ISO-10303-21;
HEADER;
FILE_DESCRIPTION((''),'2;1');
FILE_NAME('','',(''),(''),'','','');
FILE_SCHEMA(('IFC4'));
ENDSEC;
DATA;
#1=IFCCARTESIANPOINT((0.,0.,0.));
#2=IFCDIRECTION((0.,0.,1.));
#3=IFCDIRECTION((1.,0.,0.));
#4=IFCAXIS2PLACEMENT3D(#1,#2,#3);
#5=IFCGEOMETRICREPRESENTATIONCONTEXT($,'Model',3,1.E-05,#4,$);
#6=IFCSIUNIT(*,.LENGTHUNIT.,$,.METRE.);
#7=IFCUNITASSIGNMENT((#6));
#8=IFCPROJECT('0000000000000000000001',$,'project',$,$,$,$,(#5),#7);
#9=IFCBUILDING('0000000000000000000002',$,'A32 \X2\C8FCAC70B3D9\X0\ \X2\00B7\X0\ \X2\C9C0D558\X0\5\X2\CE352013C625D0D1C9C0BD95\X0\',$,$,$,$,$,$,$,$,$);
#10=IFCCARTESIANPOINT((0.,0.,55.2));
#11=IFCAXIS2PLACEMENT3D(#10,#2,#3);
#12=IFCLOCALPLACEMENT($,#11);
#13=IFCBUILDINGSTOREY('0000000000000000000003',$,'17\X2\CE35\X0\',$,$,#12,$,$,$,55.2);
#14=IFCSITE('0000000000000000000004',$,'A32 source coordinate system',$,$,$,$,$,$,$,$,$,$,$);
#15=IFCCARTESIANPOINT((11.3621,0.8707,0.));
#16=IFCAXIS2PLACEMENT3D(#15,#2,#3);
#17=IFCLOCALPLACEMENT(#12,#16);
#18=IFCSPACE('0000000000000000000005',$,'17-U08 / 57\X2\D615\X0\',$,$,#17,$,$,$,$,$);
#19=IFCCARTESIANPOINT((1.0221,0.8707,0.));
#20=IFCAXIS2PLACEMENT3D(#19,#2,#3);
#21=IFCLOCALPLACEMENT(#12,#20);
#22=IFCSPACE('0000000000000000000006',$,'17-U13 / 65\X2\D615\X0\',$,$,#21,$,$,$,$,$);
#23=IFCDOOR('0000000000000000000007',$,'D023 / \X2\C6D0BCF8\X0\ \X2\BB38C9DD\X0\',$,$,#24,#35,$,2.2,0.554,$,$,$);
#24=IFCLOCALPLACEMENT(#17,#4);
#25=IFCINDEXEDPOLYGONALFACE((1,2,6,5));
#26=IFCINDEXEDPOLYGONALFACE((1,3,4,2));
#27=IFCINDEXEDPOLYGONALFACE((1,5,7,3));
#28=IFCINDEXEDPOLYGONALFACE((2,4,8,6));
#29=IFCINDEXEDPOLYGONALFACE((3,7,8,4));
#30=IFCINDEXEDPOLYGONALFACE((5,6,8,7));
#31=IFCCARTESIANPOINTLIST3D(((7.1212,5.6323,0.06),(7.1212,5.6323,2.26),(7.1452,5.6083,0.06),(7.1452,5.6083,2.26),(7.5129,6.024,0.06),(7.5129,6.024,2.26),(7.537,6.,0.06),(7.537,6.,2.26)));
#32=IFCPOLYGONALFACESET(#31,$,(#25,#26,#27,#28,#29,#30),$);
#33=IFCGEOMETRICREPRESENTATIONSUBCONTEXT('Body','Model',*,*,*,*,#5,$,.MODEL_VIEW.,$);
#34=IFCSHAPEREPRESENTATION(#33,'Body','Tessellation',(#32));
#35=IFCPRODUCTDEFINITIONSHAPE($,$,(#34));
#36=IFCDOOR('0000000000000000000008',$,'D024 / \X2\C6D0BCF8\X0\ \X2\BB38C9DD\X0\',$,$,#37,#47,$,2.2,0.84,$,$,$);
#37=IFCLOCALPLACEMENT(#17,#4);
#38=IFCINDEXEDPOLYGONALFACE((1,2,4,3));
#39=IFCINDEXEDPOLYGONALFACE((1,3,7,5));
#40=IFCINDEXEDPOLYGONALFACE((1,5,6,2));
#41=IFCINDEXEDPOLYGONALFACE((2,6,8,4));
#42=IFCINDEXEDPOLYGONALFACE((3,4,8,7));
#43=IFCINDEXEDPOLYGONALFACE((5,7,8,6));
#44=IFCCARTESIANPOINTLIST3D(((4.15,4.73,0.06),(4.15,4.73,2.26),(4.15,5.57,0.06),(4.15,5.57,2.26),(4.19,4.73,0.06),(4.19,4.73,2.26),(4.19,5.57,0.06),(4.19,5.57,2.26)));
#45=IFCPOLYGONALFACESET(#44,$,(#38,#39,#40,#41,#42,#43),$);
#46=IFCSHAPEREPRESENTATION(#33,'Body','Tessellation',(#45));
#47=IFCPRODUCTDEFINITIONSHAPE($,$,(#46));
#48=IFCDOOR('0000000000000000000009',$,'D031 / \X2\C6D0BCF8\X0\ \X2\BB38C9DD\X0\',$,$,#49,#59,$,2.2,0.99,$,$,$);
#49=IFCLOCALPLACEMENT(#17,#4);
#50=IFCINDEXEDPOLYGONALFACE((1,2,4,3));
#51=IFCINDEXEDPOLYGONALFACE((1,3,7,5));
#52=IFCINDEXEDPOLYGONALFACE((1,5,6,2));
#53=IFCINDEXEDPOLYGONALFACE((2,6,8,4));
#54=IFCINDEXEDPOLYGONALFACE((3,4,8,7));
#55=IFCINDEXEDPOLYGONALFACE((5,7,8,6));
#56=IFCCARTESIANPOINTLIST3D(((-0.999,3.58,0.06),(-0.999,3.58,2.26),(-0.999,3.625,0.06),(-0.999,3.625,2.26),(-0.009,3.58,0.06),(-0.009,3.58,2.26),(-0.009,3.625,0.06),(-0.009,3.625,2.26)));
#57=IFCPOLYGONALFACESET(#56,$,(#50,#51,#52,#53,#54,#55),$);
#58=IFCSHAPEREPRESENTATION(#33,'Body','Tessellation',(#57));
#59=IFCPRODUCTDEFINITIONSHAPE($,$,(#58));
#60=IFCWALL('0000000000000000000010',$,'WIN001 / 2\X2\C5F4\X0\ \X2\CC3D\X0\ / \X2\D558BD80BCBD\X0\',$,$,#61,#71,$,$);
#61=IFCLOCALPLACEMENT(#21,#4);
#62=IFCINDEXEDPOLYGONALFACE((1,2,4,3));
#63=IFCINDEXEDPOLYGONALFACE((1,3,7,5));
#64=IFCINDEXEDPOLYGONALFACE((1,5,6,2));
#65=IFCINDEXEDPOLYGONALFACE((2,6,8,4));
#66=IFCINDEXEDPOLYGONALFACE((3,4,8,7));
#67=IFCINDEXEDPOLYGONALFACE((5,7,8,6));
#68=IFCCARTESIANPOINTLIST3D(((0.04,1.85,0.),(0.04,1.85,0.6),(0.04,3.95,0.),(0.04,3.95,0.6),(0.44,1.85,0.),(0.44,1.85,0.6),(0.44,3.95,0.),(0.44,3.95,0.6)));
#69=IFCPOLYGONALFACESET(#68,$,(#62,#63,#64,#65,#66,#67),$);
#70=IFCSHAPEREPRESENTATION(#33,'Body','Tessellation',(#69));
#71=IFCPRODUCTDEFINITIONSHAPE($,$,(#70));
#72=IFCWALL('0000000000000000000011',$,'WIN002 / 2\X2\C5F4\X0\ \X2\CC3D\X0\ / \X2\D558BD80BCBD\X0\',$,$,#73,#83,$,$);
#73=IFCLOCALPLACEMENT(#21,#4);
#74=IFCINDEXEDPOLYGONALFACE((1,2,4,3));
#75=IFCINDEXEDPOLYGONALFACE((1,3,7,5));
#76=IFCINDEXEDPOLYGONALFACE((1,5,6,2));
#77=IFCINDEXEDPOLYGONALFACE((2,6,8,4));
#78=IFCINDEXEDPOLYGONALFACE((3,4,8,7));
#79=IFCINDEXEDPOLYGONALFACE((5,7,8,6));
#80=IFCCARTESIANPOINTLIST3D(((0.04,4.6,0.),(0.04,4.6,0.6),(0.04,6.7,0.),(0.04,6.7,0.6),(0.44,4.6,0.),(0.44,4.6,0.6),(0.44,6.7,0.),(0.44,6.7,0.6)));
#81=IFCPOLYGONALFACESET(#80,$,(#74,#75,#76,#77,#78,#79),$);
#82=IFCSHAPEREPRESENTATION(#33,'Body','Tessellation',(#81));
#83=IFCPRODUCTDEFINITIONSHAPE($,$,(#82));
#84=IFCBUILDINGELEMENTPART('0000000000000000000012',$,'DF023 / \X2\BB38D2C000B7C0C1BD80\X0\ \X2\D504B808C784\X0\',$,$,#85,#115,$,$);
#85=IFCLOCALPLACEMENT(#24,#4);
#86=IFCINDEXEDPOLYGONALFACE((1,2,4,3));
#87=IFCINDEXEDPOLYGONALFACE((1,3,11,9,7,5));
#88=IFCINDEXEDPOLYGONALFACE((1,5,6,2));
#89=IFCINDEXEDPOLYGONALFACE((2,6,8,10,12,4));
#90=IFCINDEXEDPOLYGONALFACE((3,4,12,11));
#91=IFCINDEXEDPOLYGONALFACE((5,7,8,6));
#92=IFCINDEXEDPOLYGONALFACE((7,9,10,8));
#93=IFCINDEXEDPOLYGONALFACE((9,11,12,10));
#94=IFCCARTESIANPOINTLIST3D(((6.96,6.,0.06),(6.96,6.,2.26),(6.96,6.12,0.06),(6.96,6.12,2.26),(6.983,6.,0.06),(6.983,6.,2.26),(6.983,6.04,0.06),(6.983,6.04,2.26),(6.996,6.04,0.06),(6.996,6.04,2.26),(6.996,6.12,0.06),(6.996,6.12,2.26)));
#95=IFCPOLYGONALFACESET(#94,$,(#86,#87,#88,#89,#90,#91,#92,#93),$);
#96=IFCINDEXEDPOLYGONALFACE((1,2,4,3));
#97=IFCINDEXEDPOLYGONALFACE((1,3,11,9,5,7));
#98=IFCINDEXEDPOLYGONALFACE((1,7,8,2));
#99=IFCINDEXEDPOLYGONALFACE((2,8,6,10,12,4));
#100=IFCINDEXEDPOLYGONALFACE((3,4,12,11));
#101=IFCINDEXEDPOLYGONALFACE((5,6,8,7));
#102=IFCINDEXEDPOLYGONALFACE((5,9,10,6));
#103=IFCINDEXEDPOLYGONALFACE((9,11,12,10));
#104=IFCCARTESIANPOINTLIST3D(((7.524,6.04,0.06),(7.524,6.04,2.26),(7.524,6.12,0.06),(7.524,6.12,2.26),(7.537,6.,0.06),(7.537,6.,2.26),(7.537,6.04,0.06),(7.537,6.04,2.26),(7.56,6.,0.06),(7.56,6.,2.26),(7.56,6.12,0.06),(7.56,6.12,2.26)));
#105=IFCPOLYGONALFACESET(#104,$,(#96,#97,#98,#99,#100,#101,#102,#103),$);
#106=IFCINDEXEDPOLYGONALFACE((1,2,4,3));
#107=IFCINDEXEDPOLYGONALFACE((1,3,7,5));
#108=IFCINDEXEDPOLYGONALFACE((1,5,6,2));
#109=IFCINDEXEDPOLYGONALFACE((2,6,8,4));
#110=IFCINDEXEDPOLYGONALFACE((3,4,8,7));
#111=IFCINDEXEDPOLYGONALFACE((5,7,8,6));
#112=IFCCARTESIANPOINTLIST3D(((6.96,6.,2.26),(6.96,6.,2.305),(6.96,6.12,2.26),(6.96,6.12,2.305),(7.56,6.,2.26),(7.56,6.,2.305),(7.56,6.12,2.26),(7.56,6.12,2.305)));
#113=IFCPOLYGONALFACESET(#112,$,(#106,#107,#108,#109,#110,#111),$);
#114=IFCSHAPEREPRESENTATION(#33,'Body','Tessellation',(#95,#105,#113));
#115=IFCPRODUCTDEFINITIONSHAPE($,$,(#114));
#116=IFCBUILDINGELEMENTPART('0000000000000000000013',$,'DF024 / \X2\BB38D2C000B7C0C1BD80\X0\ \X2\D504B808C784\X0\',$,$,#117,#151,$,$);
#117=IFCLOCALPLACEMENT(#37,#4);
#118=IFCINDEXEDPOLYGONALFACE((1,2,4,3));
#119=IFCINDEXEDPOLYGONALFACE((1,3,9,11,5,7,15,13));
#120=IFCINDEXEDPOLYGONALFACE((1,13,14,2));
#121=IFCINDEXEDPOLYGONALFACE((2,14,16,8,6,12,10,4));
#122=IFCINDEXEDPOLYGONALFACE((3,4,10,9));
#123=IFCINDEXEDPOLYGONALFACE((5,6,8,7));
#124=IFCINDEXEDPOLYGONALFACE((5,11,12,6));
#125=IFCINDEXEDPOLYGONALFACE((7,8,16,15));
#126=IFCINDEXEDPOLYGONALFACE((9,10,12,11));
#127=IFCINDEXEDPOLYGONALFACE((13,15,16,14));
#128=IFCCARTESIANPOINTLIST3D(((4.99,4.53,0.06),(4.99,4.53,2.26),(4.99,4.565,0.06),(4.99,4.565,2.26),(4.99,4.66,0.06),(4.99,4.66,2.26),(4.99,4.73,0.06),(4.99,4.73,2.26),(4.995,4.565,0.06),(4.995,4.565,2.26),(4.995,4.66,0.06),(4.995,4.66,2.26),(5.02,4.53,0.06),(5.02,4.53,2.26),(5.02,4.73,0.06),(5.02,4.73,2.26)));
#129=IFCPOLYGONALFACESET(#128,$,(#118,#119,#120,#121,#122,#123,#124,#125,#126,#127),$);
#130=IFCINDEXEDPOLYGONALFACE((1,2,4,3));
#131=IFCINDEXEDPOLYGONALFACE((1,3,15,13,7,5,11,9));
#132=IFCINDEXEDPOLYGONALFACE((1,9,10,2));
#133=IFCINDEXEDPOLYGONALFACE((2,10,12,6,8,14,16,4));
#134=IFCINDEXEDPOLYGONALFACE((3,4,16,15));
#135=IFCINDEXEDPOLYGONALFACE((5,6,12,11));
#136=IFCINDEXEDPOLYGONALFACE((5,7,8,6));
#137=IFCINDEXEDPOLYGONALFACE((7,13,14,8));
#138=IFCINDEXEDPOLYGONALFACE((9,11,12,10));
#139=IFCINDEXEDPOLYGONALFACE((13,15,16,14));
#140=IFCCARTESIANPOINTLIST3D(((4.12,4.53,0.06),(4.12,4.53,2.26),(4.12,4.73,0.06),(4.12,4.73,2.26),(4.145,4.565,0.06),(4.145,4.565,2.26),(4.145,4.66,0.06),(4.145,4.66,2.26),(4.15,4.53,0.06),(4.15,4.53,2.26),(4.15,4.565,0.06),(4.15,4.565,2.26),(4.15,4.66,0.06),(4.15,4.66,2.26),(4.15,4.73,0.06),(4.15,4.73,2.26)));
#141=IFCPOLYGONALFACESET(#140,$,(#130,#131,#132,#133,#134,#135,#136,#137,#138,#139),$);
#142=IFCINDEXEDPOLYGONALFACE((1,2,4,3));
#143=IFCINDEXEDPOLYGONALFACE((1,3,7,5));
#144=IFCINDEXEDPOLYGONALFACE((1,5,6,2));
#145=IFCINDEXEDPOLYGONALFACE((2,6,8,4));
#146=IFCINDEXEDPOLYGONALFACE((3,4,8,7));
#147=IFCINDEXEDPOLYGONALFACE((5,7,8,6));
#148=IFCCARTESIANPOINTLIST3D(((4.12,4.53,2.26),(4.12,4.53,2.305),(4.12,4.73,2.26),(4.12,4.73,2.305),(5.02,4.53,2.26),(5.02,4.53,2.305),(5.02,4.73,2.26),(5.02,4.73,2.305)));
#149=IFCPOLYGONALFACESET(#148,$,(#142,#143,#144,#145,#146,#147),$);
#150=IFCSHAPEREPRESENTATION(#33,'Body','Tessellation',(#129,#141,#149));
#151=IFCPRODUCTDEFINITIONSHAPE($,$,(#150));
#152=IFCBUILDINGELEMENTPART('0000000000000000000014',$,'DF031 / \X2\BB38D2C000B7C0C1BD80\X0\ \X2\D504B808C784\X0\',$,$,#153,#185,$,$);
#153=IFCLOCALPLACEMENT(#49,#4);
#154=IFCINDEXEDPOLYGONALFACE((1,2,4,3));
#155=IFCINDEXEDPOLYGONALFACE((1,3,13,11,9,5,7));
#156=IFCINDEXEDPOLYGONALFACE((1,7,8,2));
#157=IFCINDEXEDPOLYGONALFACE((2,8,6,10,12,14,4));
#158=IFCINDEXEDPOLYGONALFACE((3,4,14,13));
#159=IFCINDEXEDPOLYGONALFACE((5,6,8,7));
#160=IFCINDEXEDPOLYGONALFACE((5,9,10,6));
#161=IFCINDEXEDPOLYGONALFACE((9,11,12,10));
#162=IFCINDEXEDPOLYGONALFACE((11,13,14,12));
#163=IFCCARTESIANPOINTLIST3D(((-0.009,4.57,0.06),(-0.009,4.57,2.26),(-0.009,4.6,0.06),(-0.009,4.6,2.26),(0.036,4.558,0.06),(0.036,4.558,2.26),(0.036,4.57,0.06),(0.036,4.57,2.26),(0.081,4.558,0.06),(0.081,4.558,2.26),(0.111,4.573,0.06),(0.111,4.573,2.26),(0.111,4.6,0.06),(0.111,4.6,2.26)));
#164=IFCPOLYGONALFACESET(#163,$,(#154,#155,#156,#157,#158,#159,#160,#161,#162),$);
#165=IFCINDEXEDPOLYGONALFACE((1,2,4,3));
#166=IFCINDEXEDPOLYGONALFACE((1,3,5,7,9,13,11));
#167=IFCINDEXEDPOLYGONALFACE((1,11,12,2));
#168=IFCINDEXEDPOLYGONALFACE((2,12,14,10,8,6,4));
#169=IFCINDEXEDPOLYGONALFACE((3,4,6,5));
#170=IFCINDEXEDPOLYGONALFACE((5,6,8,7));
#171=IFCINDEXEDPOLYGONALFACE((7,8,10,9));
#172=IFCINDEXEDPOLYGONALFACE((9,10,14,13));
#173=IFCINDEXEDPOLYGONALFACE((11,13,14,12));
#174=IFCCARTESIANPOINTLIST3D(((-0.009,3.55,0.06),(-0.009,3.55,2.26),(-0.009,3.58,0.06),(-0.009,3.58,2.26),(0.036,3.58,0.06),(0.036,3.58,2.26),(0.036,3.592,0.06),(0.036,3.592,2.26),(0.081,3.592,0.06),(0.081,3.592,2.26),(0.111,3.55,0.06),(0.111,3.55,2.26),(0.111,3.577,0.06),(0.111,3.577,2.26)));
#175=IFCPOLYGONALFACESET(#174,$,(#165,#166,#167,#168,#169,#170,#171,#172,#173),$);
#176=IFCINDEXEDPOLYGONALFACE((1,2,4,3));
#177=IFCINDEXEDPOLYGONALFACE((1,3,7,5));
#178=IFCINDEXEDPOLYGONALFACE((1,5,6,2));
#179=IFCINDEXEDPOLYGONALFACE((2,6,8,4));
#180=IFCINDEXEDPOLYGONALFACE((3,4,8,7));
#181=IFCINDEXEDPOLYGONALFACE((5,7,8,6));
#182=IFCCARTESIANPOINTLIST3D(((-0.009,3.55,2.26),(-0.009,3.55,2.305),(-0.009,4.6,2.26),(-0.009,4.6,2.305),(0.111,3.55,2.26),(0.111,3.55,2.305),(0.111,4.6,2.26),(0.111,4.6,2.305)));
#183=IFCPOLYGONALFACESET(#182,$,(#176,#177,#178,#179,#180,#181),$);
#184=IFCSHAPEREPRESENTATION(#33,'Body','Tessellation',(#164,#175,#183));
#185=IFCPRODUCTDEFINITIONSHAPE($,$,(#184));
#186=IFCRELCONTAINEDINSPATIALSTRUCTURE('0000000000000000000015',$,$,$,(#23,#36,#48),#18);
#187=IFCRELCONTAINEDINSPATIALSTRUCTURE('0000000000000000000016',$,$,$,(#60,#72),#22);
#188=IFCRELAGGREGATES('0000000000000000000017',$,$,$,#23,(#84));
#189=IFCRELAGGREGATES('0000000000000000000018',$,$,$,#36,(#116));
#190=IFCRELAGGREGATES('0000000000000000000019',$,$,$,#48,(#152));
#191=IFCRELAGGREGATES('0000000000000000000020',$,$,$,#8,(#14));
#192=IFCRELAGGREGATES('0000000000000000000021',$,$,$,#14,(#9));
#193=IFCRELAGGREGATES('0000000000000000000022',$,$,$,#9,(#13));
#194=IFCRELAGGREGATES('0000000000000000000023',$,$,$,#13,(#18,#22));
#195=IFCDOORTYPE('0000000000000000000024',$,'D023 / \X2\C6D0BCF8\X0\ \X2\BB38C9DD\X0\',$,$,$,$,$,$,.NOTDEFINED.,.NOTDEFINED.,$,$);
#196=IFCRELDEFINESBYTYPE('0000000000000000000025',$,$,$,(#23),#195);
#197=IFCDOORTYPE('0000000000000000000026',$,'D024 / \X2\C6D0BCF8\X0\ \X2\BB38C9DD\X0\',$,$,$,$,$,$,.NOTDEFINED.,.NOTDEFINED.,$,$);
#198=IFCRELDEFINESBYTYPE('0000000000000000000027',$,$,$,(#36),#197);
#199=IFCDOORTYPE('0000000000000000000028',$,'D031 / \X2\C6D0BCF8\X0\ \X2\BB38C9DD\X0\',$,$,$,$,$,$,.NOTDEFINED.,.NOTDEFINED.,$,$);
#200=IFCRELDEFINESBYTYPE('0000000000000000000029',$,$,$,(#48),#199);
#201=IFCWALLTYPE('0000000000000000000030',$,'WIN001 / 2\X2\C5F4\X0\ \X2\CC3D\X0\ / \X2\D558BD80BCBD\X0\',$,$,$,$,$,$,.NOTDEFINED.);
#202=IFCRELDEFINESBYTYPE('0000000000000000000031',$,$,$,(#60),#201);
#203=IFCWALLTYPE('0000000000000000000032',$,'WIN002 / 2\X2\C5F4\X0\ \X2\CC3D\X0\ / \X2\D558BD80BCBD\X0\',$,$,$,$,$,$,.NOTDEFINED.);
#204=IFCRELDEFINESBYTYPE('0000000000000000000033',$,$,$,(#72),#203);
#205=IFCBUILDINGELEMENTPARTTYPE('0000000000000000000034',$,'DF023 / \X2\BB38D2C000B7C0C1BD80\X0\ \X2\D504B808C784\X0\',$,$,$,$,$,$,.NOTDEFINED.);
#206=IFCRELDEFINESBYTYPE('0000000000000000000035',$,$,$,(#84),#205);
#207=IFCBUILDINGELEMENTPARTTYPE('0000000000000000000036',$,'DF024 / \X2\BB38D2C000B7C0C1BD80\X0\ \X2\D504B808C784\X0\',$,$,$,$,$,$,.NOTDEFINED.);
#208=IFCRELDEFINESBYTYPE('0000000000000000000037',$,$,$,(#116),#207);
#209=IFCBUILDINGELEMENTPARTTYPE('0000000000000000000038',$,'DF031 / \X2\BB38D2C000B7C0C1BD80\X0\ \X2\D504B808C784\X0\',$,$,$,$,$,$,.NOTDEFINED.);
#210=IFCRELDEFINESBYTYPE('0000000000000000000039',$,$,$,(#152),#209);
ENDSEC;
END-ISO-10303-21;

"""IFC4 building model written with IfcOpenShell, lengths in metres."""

from ifc_helpers import new_model, si_unit, frame, origin, origin_with_axes, place, context, subcontext, project, spatial, polyline, outline, extrude, source, transform, mapped, type_object, type_shapes, element, aggregate, save


model = new_model("IFC4")

# Units and contexts
model_context = context("Model", 3, precision=1e-05, world=origin_with_axes())
body_context = subcontext(model_context, "Body", "Model", "MODEL_VIEW")
ifc_project = project(units=[si_unit("LENGTHUNIT", "METRE")], contexts=[model_context])

# Site, building, storey, space
site = spatial("IfcSite", under=ifc_project, Name="A32 source coordinate system")
building = spatial("IfcBuilding", under=site, Name="A32 주거동 · 지하5층–옥탑지붕")
storey_placement = place(None, frame((0.0, 0.0, 55.2), z_axis=(0.0, 0.0, 1.0), x_axis=(1.0, 0.0, 0.0)))
storey = spatial("IfcBuildingStorey", under=building, at=storey_placement, Name="17층", Elevation=55.2)
space_1_placement = place(storey_placement, frame((11.3621, 0.8707, 0.0), z_axis=(0.0, 0.0, 1.0), x_axis=(1.0, 0.0, 0.0)))
space_1 = spatial("IfcSpace", under=storey, at=space_1_placement, Name="17-U08 / 57형")

# Doors
door_type_1 = type_object("IfcDoorType", Name="D023 / 원본 문짝", OperationType="NOTDEFINED", PredefinedType="NOTDEFINED")
shared_shape_1 = source(origin(), body_context, "Body", "SweptSolid", [
    extrude(outline(polyline([(7.537, 6.0), (7.1452, 5.6083), (7.1212, 5.6323), (7.5129, 6.024), (7.537, 6.0)])), frame((0.0, 0.0, 0.06)), (0.0, 0.0, 1.0), 2.2),
])
type_shapes(door_type_1, [shared_shape_1])
door_1_placement = place(space_1_placement, origin_with_axes())
door_1 = element("IfcDoor", 1, at=door_1_placement, inside=space_1, type_object=door_type_1, Name="D023 / 원본 문짝", OverallHeight=2.2, OverallWidth=0.554, context=body_context, shape_type="MappedRepresentation", body=[
    mapped(shared_shape_1, transform((0.0, 0.0, 0.0), scale=1.0)),
])
door_type_2 = type_object("IfcDoorType", Name="D024 / 원본 문짝", OperationType="NOTDEFINED", PredefinedType="NOTDEFINED")
shared_shape_2 = source(origin(), body_context, "Body", "SweptSolid", [
    extrude(outline(polyline([(4.15, 4.73), (4.15, 5.57), (4.19, 5.57), (4.19, 4.73), (4.15, 4.73)])), frame((0.0, 0.0, 0.06)), (0.0, 0.0, 1.0), 2.2),
])
type_shapes(door_type_2, [shared_shape_2])
door_2_placement = place(space_1_placement, origin_with_axes())
door_2 = element("IfcDoor", 2, at=door_2_placement, inside=space_1, type_object=door_type_2, Name="D024 / 원본 문짝", OverallHeight=2.2, OverallWidth=0.84, context=body_context, shape_type="MappedRepresentation", body=[
    mapped(shared_shape_2, transform((0.0, 0.0, 0.0), scale=1.0)),
])
door_type_3 = type_object("IfcDoorType", Name="D031 / 원본 문짝", OperationType="NOTDEFINED", PredefinedType="NOTDEFINED")
shared_shape_3 = source(origin(), body_context, "Body", "SweptSolid", [
    extrude(outline(polyline([(-0.009, 3.58), (-0.999, 3.58), (-0.999, 3.625), (-0.009, 3.625), (-0.009, 3.58)])), frame((0.0, 0.0, 0.06)), (0.0, 0.0, 1.0), 2.2),
])
type_shapes(door_type_3, [shared_shape_3])
door_3_placement = place(space_1_placement, origin_with_axes())
door_3 = element("IfcDoor", 3, at=door_3_placement, inside=space_1, type_object=door_type_3, Name="D031 / 원본 문짝", OverallHeight=2.2, OverallWidth=0.99, context=body_context, shape_type="MappedRepresentation", body=[
    mapped(shared_shape_3, transform((0.0, 0.0, 0.0), scale=1.0)),
])

# Shared definitions
space_2_placement = place(storey_placement, frame((1.0221, 0.8707, 0.0), z_axis=(0.0, 0.0, 1.0), x_axis=(1.0, 0.0, 0.0)))
space_2 = spatial("IfcSpace", under=storey, at=space_2_placement, Name="17-U13 / 65형")

# Walls
wall_type_1 = type_object("IfcWallType", Name="WIN001 / 2열 창 / 하부벽", PredefinedType="NOTDEFINED")
shared_shape_4 = source(origin(), body_context, "Body", "SweptSolid", [
    extrude(outline(polyline([(0.04, 3.95), (0.44, 3.95), (0.44, 1.85), (0.04, 1.85), (0.04, 3.95)])), origin(), (0.0, 0.0, 1.0), 0.6),
])
type_shapes(wall_type_1, [shared_shape_4])
wall_1_placement = place(space_2_placement, origin_with_axes())
element("IfcWall", 4, at=wall_1_placement, inside=space_2, type_object=wall_type_1, Name="WIN001 / 2열 창 / 하부벽", context=body_context, shape_type="MappedRepresentation", body=[
    mapped(shared_shape_4, transform((0.0, 0.0, 0.0), scale=1.0)),
])
wall_type_2 = type_object("IfcWallType", Name="WIN002 / 2열 창 / 하부벽", PredefinedType="NOTDEFINED")
shared_shape_5 = source(origin(), body_context, "Body", "SweptSolid", [
    extrude(outline(polyline([(0.04, 6.7), (0.44, 6.7), (0.44, 4.6), (0.04, 4.6), (0.04, 6.7)])), origin(), (0.0, 0.0, 1.0), 0.6),
])
type_shapes(wall_type_2, [shared_shape_5])
wall_2_placement = place(space_2_placement, origin_with_axes())
element("IfcWall", 5, at=wall_2_placement, inside=space_2, type_object=wall_type_2, Name="WIN002 / 2열 창 / 하부벽", context=body_context, shape_type="MappedRepresentation", body=[
    mapped(shared_shape_5, transform((0.0, 0.0, 0.0), scale=1.0)),
])

# Building element parts
building_element_part_type_1 = type_object("IfcBuildingElementPartType", Name="DF023 / 문틀·상부 프레임", PredefinedType="NOTDEFINED")
shared_shape_6 = source(origin(), body_context, "Body", "SweptSolid", [
    extrude(outline(polyline([(6.996, 6.12), (6.996, 6.04), (6.983, 6.04), (6.983, 6.0), (6.96, 6.0), (6.96, 6.12), (6.996, 6.12)])), frame((0.0, 0.0, 0.06)), (0.0, 0.0, 1.0), 2.2),
    extrude(outline(polyline([(7.56, 6.0), (7.537, 6.0), (7.537, 6.04), (7.524, 6.04), (7.524, 6.12), (7.56, 6.12), (7.56, 6.0)])), frame((0.0, 0.0, 0.06)), (0.0, 0.0, 1.0), 2.2),
    extrude(outline(polyline([(6.96, 6.0), (6.96, 6.12), (7.56, 6.12), (7.56, 6.0), (6.96, 6.0)])), frame((0.0, 0.0, 2.26)), (0.0, 0.0, 1.0), 0.045),
])
type_shapes(building_element_part_type_1, [shared_shape_6])
building_element_part_1_placement = place(door_1_placement, origin_with_axes())
building_element_part_1 = element("IfcBuildingElementPart", 6, at=building_element_part_1_placement, type_object=building_element_part_type_1, Name="DF023 / 문틀·상부 프레임", context=body_context, shape_type="MappedRepresentation", body=[
    mapped(shared_shape_6, transform((0.0, 0.0, 0.0), scale=1.0)),
])
aggregate(door_1, [building_element_part_1])
building_element_part_type_2 = type_object("IfcBuildingElementPartType", Name="DF024 / 문틀·상부 프레임", PredefinedType="NOTDEFINED")
shared_shape_7 = source(origin(), body_context, "Body", "SweptSolid", [
    extrude(outline(polyline([(5.02, 4.53), (4.99, 4.53), (4.99, 4.565), (4.995, 4.565), (4.995, 4.66), (4.99, 4.66), (4.99, 4.73), (5.02, 4.73), (5.02, 4.53)])), frame((0.0, 0.0, 0.06)), (0.0, 0.0, 1.0), 2.2),
    extrude(outline(polyline([(4.15, 4.73), (4.15, 4.66), (4.145, 4.66), (4.145, 4.565), (4.15, 4.565), (4.15, 4.53), (4.12, 4.53), (4.12, 4.73), (4.15, 4.73)])), frame((0.0, 0.0, 0.06)), (0.0, 0.0, 1.0), 2.2),
    extrude(outline(polyline([(4.12, 4.53), (4.12, 4.73), (5.02, 4.73), (5.02, 4.53), (4.12, 4.53)])), frame((0.0, 0.0, 2.26)), (0.0, 0.0, 1.0), 0.045),
])
type_shapes(building_element_part_type_2, [shared_shape_7])
building_element_part_2_placement = place(door_2_placement, origin_with_axes())
building_element_part_2 = element("IfcBuildingElementPart", 7, at=building_element_part_2_placement, type_object=building_element_part_type_2, Name="DF024 / 문틀·상부 프레임", context=body_context, shape_type="MappedRepresentation", body=[
    mapped(shared_shape_7, transform((0.0, 0.0, 0.0), scale=1.0)),
])
aggregate(door_2, [building_element_part_2])
building_element_part_type_3 = type_object("IfcBuildingElementPartType", Name="DF031 / 문틀·상부 프레임", PredefinedType="NOTDEFINED")
shared_shape_8 = source(origin(), body_context, "Body", "SweptSolid", [
    extrude(outline(polyline([(0.111, 4.6), (0.111, 4.573), (0.081, 4.558), (0.036, 4.558), (0.036, 4.57), (-0.009, 4.57), (-0.009, 4.6), (0.111, 4.6)])), frame((0.0, 0.0, 0.06)), (0.0, 0.0, 1.0), 2.2),
    extrude(outline(polyline([(-0.009, 3.58), (0.036, 3.58), (0.036, 3.592), (0.081, 3.592), (0.111, 3.577), (0.111, 3.55), (-0.009, 3.55), (-0.009, 3.58)])), frame((0.0, 0.0, 0.06)), (0.0, 0.0, 1.0), 2.2),
    extrude(outline(polyline([(-0.009, 3.55), (-0.009, 4.6), (0.111, 4.6), (0.111, 3.55), (-0.009, 3.55)])), frame((0.0, 0.0, 2.26)), (0.0, 0.0, 1.0), 0.045),
])
type_shapes(building_element_part_type_3, [shared_shape_8])
building_element_part_3_placement = place(door_3_placement, origin_with_axes())
building_element_part_3 = element("IfcBuildingElementPart", 8, at=building_element_part_3_placement, type_object=building_element_part_type_3, Name="DF031 / 문틀·상부 프레임", context=body_context, shape_type="MappedRepresentation", body=[
    mapped(shared_shape_8, transform((0.0, 0.0, 0.0), scale=1.0)),
])
aggregate(door_3, [building_element_part_3])

save(model, "model.ifc")
